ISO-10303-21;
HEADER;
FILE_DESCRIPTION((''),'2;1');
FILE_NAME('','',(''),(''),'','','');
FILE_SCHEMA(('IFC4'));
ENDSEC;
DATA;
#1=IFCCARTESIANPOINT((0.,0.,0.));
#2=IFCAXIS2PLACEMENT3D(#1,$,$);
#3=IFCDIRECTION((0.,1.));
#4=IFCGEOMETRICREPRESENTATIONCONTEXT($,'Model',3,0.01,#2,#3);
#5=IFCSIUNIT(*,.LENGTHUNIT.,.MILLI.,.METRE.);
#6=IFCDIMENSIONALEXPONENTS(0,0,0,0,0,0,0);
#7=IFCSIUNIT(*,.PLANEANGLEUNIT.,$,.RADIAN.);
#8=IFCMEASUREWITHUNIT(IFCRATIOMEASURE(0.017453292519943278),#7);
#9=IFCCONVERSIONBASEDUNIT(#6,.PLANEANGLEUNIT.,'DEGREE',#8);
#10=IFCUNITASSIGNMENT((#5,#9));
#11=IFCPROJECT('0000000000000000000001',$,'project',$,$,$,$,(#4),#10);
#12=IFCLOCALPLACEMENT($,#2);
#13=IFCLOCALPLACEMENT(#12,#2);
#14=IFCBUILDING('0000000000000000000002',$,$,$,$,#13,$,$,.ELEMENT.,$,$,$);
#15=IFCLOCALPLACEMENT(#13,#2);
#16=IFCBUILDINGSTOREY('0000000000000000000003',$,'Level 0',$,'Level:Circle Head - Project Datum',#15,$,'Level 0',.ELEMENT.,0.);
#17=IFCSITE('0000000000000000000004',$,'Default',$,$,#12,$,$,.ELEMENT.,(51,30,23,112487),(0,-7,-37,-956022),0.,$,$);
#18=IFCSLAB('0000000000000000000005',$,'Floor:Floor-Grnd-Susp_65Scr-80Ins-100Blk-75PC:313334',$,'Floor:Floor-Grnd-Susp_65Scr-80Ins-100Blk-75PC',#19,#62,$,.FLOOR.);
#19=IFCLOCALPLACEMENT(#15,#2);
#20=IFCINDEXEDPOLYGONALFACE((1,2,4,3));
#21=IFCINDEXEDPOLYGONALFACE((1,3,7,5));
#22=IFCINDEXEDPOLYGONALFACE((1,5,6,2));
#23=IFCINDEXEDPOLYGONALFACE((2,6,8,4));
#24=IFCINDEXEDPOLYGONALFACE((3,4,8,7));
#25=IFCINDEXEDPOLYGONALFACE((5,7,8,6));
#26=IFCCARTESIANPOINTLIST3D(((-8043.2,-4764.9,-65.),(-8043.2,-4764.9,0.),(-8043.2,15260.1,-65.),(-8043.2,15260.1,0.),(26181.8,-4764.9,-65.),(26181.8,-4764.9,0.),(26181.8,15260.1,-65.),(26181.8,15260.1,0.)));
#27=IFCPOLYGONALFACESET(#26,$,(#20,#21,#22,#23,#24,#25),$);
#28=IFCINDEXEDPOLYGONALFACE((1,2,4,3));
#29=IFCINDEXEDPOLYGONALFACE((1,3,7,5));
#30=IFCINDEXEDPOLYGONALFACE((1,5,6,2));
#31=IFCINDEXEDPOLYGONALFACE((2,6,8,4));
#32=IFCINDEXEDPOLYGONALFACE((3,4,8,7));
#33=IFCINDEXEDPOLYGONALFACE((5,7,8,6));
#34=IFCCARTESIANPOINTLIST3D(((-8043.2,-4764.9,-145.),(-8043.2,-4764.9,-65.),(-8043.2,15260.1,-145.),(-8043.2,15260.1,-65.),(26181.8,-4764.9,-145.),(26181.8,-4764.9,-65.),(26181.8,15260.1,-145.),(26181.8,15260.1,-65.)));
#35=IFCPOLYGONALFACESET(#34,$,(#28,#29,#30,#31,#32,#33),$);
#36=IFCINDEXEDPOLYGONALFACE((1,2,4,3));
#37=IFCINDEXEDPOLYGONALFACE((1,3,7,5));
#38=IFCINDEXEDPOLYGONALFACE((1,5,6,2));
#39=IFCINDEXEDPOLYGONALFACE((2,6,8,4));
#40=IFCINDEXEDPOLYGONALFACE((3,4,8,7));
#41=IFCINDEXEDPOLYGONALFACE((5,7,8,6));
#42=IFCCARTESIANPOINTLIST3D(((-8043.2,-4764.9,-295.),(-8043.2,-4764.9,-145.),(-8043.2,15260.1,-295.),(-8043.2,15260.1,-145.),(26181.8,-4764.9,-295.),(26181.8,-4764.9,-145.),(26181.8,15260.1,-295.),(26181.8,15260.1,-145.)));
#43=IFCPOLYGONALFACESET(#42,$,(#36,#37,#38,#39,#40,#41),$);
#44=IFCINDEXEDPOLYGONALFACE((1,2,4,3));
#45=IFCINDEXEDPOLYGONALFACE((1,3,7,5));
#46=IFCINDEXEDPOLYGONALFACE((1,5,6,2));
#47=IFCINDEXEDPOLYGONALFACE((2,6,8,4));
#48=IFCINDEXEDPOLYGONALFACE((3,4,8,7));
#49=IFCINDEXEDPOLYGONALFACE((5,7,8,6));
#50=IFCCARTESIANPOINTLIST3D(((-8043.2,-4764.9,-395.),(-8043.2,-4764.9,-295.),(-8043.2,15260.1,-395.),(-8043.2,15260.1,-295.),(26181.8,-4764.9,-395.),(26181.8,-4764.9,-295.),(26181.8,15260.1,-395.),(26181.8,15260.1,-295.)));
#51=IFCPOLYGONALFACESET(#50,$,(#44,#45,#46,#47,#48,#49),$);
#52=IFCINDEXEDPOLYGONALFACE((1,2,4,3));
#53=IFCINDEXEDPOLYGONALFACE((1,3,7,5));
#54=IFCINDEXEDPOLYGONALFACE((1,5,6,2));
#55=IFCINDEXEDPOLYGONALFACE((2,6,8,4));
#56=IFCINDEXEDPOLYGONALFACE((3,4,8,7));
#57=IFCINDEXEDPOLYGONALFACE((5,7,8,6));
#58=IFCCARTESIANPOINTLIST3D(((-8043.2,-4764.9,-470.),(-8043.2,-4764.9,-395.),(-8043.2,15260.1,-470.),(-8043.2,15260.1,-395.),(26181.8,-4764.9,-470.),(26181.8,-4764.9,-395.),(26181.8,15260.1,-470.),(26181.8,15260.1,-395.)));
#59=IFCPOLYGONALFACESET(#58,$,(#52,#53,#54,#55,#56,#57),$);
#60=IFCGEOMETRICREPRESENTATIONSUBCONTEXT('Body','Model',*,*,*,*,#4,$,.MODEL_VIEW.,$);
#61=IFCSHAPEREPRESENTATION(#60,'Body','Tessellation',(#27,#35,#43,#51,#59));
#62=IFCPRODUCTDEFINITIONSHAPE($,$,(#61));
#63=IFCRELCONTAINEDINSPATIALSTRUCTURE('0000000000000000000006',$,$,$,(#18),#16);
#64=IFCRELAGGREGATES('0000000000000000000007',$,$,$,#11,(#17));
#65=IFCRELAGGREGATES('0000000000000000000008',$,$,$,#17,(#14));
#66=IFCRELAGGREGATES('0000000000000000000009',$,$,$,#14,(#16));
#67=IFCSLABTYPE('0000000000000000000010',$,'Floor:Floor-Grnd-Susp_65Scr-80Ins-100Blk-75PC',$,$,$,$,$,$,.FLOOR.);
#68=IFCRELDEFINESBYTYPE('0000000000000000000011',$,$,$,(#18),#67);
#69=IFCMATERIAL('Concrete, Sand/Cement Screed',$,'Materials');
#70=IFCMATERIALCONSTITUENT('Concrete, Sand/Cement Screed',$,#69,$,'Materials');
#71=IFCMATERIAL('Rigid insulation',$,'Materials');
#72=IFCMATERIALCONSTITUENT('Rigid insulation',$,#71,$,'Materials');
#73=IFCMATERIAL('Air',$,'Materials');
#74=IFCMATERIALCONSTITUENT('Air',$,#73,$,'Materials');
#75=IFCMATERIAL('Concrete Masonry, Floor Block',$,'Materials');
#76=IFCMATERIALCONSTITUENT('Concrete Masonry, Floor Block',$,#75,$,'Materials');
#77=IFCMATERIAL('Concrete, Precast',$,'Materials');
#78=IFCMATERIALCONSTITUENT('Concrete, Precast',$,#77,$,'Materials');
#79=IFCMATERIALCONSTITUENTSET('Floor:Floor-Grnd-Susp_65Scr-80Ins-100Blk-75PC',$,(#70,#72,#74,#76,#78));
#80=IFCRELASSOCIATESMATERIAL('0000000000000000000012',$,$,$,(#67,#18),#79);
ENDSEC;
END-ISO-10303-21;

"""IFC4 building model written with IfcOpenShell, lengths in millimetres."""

from ifc_helpers import new_model, entity, si_unit, converted_unit, direction, frame, origin, place, context, subcontext, project, spatial, indexed_curve, outline, extrude, material, constituent, constituent_set, type_object, element, save


model = new_model("IFC4")

# Units and contexts
model_context = context("Model", 3, precision=0.01, world=origin(), true_north=direction((0.0, 1.0)))
body_context = subcontext(model_context, "Body", "Model", "MODEL_VIEW")
ifc_project = project(units=[si_unit("LENGTHUNIT", "METRE", prefix="MILLI"), converted_unit("PLANEANGLEUNIT", "DEGREE", entity("IfcRatioMeasure", 0.017453292519943278), si_unit("PLANEANGLEUNIT", "RADIAN"), dimensions=[0, 0, 0, 0, 0, 0, 0])], contexts=[model_context])

# Site, building, storey
site_placement = place(None, origin())
site = spatial("IfcSite", under=ifc_project, at=site_placement, Name="Default", CompositionType="ELEMENT", RefLatitude=(51, 30, 23, 112487), RefLongitude=(0, -7, -37, -956022), RefElevation=0.0)
building_placement = place(site_placement, origin())
building = spatial("IfcBuilding", under=site, at=building_placement, CompositionType="ELEMENT")
storey_placement = place(building_placement, origin())
storey = spatial("IfcBuildingStorey", under=building, at=storey_placement, Name="Level 0", ObjectType="Level:Circle Head - Project Datum", LongName="Level 0", CompositionType="ELEMENT", Elevation=0.0)

# Slab
ifc_material_1 = material(Name="Concrete, Sand/Cement Screed", Category="Materials")
ifc_constituent_1 = constituent(ifc_material_1, Name="Concrete, Sand/Cement Screed", Category="Materials")
ifc_material_2 = material(Name="Rigid insulation", Category="Materials")
ifc_constituent_2 = constituent(ifc_material_2, Name="Rigid insulation", Category="Materials")
ifc_material_3 = material(Name="Air", Category="Materials")
ifc_constituent_3 = constituent(ifc_material_3, Name="Air", Category="Materials")
ifc_material_4 = material(Name="Concrete Masonry, Floor Block", Category="Materials")
ifc_constituent_4 = constituent(ifc_material_4, Name="Concrete Masonry, Floor Block", Category="Materials")
ifc_material_5 = material(Name="Concrete, Precast", Category="Materials")
ifc_constituent_5 = constituent(ifc_material_5, Name="Concrete, Precast", Category="Materials")
ifc_constituent_set_1 = constituent_set(constituents=[ifc_constituent_1, ifc_constituent_2, ifc_constituent_3, ifc_constituent_4, ifc_constituent_5], Name="Floor:Floor-Grnd-Susp_65Scr-80Ins-100Blk-75PC")
slab_type = type_object("IfcSlabType", Name="Floor:Floor-Grnd-Susp_65Scr-80Ins-100Blk-75PC", PredefinedType="FLOOR", material=ifc_constituent_set_1)
slab_placement = place(storey_placement, origin())
element("IfcSlab", 1, at=slab_placement, inside=storey, type_object=slab_type, material=ifc_constituent_set_1, Name="Floor:Floor-Grnd-Susp_65Scr-80Ins-100Blk-75PC:313334", ObjectType="Floor:Floor-Grnd-Susp_65Scr-80Ins-100Blk-75PC", PredefinedType="FLOOR", context=body_context, shape_type="SweptSolid", body=[
    extrude(outline(indexed_curve([(-17112.5, -10012.5), (17112.5, -10012.5), (17112.5, 10012.5), (-17112.5, 10012.5), (-17112.5, -10012.5)], self_intersect=False)), frame((9069.3, 5247.6, -65.0), z_axis=(0.0, 0.0, 1.0), x_axis=(-1.0, 0.0, 0.0)), (0.0, 0.0, 1.0), 65.0),
    extrude(outline(indexed_curve([(-17112.5, -10012.5), (17112.5, -10012.5), (17112.5, 10012.5), (-17112.5, 10012.5), (-17112.5, -10012.5)], self_intersect=False)), frame((9069.3, 5247.6, -145.0), z_axis=(0.0, 0.0, 1.0), x_axis=(-1.0, 0.0, 0.0)), (0.0, 0.0, 1.0), 80.0),
    extrude(outline(indexed_curve([(-17112.5, -10012.5), (17112.5, -10012.5), (17112.5, 10012.5), (-17112.5, 10012.5), (-17112.5, -10012.5)], self_intersect=False)), frame((9069.3, 5247.6, -295.0), z_axis=(0.0, 0.0, 1.0), x_axis=(-1.0, 0.0, 0.0)), (0.0, 0.0, 1.0), 150.0),
    extrude(outline(indexed_curve([(-17112.5, -10012.5), (17112.5, -10012.5), (17112.5, 10012.5), (-17112.5, 10012.5), (-17112.5, -10012.5)], self_intersect=False)), frame((9069.3, 5247.6, -395.0), z_axis=(0.0, 0.0, 1.0), x_axis=(-1.0, 0.0, 0.0)), (0.0, 0.0, 1.0), 100.0),
    extrude(outline(indexed_curve([(-17112.5, -10012.5), (17112.5, -10012.5), (17112.5, 10012.5), (-17112.5, 10012.5), (-17112.5, -10012.5)], self_intersect=False)), frame((9069.3, 5247.6, -470.0), z_axis=(0.0, 0.0, 1.0), x_axis=(-1.0, 0.0, 0.0)), (0.0, 0.0, 1.0), 75.0),
])

save(model, "model.ifc")
